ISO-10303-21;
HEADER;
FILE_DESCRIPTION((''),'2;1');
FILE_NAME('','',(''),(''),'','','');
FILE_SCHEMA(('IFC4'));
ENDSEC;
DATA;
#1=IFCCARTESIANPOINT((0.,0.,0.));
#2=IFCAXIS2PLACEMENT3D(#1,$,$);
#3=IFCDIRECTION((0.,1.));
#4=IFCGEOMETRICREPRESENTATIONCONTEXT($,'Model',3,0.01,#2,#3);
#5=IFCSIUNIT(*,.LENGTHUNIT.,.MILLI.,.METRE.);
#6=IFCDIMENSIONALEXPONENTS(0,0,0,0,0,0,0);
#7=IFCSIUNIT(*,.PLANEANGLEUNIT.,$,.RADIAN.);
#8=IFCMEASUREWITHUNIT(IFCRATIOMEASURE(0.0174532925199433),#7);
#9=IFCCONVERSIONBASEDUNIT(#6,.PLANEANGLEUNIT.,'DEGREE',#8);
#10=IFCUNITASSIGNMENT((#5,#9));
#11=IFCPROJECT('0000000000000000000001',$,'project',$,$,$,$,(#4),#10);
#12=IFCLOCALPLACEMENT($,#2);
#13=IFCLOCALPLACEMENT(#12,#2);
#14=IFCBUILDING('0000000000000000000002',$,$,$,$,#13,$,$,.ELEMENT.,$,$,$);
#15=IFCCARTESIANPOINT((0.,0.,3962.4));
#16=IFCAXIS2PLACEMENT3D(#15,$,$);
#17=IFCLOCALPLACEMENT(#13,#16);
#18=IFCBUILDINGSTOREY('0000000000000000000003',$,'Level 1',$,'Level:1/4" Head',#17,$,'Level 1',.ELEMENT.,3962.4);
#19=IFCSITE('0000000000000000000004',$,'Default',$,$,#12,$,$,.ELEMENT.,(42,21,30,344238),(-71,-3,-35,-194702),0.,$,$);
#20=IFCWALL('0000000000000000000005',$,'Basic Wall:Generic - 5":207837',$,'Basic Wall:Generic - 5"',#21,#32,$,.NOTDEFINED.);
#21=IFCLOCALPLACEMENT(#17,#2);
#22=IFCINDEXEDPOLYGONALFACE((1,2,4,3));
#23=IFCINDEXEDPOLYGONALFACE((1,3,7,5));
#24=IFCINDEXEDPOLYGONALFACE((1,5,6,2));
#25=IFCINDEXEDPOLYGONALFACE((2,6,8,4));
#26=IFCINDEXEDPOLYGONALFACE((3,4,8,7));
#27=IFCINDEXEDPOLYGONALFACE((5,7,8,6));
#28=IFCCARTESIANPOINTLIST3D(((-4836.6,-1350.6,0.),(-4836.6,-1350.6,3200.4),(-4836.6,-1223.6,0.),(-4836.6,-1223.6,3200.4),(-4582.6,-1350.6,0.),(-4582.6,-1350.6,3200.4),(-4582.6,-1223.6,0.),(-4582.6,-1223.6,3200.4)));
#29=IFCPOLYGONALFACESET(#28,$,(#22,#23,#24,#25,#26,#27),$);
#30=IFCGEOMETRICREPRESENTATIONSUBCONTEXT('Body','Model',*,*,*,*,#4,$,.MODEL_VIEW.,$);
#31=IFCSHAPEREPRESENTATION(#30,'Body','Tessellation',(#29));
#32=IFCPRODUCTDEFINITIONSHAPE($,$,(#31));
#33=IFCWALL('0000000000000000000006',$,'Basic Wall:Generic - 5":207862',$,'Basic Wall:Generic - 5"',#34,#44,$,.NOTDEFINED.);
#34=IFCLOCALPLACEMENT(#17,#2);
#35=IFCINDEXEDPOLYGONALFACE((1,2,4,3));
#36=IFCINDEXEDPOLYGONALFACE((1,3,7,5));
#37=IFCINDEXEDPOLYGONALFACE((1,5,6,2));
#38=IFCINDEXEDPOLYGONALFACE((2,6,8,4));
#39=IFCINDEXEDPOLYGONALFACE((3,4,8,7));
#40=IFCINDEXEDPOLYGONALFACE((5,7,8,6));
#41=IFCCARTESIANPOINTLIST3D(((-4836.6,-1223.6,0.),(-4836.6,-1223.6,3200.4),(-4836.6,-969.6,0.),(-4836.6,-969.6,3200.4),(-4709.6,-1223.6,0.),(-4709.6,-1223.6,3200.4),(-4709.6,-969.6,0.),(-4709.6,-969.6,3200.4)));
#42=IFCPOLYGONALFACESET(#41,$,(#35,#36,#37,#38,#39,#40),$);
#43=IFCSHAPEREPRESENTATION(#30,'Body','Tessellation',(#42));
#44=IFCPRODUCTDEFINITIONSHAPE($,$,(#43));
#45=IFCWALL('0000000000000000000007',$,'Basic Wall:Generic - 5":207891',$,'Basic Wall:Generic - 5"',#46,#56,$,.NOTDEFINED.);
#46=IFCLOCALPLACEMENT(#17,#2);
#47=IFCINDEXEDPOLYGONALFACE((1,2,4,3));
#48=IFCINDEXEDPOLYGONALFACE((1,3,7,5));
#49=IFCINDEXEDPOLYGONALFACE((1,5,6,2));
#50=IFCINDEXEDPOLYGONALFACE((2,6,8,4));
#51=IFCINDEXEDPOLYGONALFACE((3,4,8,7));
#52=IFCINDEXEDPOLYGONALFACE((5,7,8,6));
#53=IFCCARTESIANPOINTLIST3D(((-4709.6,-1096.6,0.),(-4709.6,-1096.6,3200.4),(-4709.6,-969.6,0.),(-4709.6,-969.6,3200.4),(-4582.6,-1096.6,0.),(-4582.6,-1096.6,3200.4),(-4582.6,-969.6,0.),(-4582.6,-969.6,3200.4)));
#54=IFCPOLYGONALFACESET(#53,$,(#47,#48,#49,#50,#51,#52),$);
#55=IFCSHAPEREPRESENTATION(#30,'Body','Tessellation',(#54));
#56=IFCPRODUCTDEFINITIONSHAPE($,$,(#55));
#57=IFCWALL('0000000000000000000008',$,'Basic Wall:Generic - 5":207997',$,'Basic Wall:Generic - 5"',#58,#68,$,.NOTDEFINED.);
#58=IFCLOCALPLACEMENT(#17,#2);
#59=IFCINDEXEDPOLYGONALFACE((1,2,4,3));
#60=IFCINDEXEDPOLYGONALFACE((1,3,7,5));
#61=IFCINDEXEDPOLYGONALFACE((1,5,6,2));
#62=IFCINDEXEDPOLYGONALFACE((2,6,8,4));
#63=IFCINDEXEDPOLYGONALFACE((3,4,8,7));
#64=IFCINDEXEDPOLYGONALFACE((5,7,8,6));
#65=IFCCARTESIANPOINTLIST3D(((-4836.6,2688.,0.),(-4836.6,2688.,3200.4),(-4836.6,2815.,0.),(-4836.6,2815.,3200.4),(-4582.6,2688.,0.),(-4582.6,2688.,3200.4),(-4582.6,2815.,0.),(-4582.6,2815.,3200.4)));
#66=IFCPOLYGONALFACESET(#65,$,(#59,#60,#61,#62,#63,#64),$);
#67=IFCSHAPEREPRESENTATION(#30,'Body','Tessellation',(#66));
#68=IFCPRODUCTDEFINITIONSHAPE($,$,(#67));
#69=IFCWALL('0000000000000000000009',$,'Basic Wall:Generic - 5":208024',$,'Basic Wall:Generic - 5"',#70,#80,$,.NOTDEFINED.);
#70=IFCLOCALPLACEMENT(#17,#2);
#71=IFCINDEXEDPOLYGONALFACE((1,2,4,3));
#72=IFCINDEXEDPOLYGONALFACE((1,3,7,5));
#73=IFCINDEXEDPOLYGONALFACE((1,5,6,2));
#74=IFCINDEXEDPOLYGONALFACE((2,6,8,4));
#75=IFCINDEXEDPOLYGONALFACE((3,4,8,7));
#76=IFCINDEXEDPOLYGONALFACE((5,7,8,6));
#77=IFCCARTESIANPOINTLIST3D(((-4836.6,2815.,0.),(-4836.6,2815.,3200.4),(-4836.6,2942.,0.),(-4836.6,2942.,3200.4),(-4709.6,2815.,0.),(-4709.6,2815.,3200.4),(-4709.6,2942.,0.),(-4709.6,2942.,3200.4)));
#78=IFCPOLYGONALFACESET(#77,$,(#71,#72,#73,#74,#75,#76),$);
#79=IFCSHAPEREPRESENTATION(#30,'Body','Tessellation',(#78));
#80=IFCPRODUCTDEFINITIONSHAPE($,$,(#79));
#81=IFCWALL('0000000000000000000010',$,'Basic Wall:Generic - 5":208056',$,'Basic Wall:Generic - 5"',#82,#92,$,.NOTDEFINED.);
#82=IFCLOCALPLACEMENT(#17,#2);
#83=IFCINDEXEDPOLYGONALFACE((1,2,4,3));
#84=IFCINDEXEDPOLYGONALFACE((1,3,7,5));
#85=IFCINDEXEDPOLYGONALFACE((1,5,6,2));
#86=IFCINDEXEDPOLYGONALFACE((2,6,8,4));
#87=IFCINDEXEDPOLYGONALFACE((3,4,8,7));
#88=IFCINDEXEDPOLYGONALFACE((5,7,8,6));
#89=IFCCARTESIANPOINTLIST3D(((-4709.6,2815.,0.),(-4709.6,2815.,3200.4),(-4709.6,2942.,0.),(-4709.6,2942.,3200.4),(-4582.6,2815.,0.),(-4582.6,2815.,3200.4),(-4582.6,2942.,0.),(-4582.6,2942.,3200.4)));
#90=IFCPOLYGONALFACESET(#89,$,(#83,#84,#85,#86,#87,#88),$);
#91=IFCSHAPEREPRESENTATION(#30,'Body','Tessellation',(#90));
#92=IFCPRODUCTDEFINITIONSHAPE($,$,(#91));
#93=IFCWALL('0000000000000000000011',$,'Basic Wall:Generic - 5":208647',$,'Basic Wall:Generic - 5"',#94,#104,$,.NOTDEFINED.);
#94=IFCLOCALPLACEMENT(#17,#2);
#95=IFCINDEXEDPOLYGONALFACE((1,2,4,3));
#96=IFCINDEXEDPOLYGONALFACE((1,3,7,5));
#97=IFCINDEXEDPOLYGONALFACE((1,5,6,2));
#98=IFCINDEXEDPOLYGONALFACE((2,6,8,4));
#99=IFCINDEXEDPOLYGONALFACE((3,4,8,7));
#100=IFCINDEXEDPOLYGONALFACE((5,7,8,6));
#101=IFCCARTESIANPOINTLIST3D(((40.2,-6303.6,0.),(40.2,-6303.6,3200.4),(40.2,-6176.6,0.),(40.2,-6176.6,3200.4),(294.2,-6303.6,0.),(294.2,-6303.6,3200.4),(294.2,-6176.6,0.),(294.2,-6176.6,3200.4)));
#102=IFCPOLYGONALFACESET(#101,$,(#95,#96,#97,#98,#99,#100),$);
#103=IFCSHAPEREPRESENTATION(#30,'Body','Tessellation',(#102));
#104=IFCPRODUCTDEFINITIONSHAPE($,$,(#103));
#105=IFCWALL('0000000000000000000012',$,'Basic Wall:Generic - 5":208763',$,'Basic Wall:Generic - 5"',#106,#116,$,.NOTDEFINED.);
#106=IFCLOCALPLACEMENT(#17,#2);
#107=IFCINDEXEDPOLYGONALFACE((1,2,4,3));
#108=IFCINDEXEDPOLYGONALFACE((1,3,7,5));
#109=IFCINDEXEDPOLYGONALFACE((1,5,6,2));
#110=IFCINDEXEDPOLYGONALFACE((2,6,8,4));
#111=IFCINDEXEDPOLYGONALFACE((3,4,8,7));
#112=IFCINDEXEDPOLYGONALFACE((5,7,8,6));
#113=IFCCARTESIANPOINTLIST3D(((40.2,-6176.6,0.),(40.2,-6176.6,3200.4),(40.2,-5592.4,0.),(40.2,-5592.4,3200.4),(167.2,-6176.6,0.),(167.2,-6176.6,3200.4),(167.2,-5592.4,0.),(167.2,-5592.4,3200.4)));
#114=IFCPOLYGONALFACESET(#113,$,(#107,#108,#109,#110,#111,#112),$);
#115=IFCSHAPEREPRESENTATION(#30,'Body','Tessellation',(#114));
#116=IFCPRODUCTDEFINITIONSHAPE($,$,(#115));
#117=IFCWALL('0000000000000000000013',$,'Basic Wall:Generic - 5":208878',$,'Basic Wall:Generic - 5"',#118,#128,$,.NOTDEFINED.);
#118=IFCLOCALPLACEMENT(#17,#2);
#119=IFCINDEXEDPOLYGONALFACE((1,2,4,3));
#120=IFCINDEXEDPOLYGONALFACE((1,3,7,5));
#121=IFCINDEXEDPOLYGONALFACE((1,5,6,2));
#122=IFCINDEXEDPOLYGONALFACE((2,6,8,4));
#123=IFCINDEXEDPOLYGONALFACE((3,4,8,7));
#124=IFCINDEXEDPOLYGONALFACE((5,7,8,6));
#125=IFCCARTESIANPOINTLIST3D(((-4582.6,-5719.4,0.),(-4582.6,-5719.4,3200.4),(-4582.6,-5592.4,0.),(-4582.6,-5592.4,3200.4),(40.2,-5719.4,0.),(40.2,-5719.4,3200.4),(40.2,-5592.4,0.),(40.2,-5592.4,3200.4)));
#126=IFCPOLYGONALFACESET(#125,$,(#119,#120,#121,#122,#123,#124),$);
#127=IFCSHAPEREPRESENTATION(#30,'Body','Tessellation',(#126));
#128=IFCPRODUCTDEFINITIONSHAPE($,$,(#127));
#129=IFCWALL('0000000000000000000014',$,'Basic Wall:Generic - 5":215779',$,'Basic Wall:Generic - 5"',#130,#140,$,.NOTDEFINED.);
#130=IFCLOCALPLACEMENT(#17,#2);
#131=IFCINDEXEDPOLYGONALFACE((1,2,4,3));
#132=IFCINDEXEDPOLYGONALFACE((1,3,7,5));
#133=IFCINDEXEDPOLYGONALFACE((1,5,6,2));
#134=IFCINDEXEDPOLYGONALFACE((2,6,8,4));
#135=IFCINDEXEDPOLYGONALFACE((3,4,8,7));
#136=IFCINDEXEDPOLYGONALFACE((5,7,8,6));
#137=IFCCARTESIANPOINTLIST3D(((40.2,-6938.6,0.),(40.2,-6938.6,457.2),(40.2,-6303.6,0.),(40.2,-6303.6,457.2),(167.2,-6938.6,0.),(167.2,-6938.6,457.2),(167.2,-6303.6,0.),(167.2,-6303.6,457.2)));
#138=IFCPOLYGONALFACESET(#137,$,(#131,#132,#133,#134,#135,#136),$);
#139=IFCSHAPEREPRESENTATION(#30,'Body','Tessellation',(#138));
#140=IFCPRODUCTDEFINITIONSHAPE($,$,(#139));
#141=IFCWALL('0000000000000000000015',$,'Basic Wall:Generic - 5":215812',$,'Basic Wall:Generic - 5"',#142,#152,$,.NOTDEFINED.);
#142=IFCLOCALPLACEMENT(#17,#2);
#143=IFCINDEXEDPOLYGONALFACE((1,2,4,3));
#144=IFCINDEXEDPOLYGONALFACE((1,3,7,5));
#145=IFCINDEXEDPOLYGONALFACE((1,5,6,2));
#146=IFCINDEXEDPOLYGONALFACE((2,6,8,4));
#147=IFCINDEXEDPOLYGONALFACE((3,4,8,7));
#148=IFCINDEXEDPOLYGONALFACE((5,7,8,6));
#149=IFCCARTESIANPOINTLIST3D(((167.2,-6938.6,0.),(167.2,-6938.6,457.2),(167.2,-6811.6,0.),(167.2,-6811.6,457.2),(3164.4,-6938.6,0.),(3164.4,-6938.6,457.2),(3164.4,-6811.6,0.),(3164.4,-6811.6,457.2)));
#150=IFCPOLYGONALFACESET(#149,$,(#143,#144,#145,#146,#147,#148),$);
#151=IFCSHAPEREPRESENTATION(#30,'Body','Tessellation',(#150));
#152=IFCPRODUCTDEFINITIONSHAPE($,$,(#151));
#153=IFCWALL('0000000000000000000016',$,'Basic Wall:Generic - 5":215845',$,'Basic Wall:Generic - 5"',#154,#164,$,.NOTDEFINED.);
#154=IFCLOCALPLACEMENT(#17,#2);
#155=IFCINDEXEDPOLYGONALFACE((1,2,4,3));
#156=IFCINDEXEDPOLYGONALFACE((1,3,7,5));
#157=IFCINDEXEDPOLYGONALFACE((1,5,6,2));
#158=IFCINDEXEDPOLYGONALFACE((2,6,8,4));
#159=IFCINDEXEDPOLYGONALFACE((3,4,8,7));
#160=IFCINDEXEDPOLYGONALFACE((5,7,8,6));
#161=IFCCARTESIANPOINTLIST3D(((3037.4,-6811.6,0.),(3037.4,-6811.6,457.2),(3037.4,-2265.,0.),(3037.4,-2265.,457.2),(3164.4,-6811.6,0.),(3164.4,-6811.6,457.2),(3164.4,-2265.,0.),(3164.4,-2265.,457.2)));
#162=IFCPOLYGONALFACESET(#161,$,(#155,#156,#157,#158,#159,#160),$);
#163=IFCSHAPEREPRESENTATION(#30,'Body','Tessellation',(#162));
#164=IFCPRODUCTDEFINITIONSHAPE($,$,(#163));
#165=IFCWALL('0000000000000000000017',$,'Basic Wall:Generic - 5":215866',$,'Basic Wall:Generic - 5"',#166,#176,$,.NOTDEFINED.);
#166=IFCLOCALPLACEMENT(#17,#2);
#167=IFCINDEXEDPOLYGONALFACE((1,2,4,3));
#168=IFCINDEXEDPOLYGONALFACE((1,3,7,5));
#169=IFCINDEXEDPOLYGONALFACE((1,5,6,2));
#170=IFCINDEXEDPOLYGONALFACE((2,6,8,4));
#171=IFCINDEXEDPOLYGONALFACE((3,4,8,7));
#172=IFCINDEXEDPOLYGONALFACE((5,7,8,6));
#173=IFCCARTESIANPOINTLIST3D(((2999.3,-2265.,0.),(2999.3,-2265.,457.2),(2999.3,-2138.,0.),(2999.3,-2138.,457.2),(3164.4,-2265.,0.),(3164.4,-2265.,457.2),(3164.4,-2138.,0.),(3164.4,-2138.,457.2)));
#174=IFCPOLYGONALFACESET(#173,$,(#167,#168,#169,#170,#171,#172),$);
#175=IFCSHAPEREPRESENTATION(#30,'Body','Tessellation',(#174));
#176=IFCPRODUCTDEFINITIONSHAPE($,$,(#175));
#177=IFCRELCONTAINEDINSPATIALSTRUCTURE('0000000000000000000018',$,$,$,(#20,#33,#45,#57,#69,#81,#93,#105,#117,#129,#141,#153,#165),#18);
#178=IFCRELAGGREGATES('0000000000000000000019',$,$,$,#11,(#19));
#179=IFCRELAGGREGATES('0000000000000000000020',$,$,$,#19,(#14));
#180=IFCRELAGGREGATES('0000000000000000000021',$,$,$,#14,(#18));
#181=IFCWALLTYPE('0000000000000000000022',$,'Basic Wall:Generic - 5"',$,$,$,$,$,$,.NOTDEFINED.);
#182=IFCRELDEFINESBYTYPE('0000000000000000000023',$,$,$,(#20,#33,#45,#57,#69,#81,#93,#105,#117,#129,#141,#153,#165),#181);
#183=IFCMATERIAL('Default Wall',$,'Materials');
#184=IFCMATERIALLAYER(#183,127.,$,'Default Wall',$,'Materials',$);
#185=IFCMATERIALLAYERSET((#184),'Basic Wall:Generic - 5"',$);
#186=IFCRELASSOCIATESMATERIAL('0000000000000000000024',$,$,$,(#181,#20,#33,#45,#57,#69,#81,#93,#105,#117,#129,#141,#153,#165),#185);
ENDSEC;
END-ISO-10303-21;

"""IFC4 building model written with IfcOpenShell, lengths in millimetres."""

from ifc_helpers import new_model, entity, si_unit, converted_unit, direction, frame, origin, place, context, subcontext, project, spatial, indexed_curve, outline, extrude, material, layer, layer_set, type_object, element, save


model = new_model("IFC4")

# Units and contexts
model_context = context("Model", 3, precision=0.01, world=origin(), true_north=direction((0.0, 1.0)))
body_context = subcontext(model_context, "Body", "Model", "MODEL_VIEW")
ifc_project = project(units=[si_unit("LENGTHUNIT", "METRE", prefix="MILLI"), converted_unit("PLANEANGLEUNIT", "DEGREE", entity("IfcRatioMeasure", 0.0174532925199433), si_unit("PLANEANGLEUNIT", "RADIAN"), dimensions=[0, 0, 0, 0, 0, 0, 0])], contexts=[model_context])

# Site, building, storey
site_placement = place(None, origin())
site = spatial("IfcSite", under=ifc_project, at=site_placement, Name="Default", CompositionType="ELEMENT", RefLatitude=(42, 21, 30, 344238), RefLongitude=(-71, -3, -35, -194702), RefElevation=0.0)
building_placement = place(site_placement, origin())
building = spatial("IfcBuilding", under=site, at=building_placement, CompositionType="ELEMENT")
storey_placement = place(building_placement, frame((0.0, 0.0, 3962.4)))
storey = spatial("IfcBuildingStorey", under=building, at=storey_placement, Name="Level 1", ObjectType="Level:1/4\" Head", LongName="Level 1", CompositionType="ELEMENT", Elevation=3962.4)

# Walls
ifc_material_1 = material(Name="Default Wall", Category="Materials")
ifc_layer_1 = layer(ifc_material_1, 127.0, Name="Default Wall", Category="Materials")
ifc_layer_set_1 = layer_set([ifc_layer_1], Name="Basic Wall:Generic - 5\"")
wall_type = type_object("IfcWallType", Name="Basic Wall:Generic - 5\"", PredefinedType="NOTDEFINED", material=ifc_layer_set_1)
wall_1_placement = place(storey_placement, frame((-4582.6, -1287.1, 0.0), z_axis=(0.0, 0.0, 1.0), x_axis=(-1.0, 0.0, 0.0)))
element("IfcWall", 1, at=wall_1_placement, inside=storey, type_object=wall_type, material=ifc_layer_set_1, Name="Basic Wall:Generic - 5\":207837", ObjectType="Basic Wall:Generic - 5\"", PredefinedType="NOTDEFINED", context=body_context, shape_type="SweptSolid", body=[
    extrude(outline(indexed_curve([(254.0, 63.5), (0.0, 63.5), (0.0, -63.5), (254.0, -63.5), (254.0, 63.5)], self_intersect=False)), origin(), (0.0, 0.0, 1.0), 3200.4),
])
wall_2_placement = place(storey_placement, frame((-4773.1, -1223.6, 0.0), z_axis=(0.0, 0.0, 1.0), x_axis=(0.0, 1.0, 0.0)))
element("IfcWall", 2, at=wall_2_placement, inside=storey, type_object=wall_type, material=ifc_layer_set_1, Name="Basic Wall:Generic - 5\":207862", ObjectType="Basic Wall:Generic - 5\"", PredefinedType="NOTDEFINED", context=body_context, shape_type="SweptSolid", body=[
    extrude(outline(indexed_curve([(254.0, 63.5), (0.0, 63.5), (0.0, -63.5), (254.0, -63.5), (254.0, 63.5)], self_intersect=False)), origin(), (0.0, 0.0, 1.0), 3200.4),
])
wall_3_placement = place(storey_placement, frame((-4709.6, -1033.1, 0.0)))
element("IfcWall", 3, at=wall_3_placement, inside=storey, type_object=wall_type, material=ifc_layer_set_1, Name="Basic Wall:Generic - 5\":207891", ObjectType="Basic Wall:Generic - 5\"", PredefinedType="NOTDEFINED", context=body_context, shape_type="SweptSolid", body=[
    extrude(outline(indexed_curve([(127.0, 63.5), (0.0, 63.5), (0.0, -63.5), (127.0, -63.5), (127.0, 63.5)], self_intersect=False)), origin(), (0.0, 0.0, 1.0), 3200.4),
])
wall_4_placement = place(storey_placement, frame((-4582.6, 2751.5, 0.0), z_axis=(0.0, 0.0, 1.0), x_axis=(-1.0, 0.0, 0.0)))
element("IfcWall", 4, at=wall_4_placement, inside=storey, type_object=wall_type, material=ifc_layer_set_1, Name="Basic Wall:Generic - 5\":207997", ObjectType="Basic Wall:Generic - 5\"", PredefinedType="NOTDEFINED", context=body_context, shape_type="SweptSolid", body=[
    extrude(outline(indexed_curve([(254.0, 63.5), (0.0, 63.5), (0.0, -63.5), (254.0, -63.5), (254.0, 63.5)], self_intersect=False)), origin(), (0.0, 0.0, 1.0), 3200.4),
])
wall_5_placement = place(storey_placement, frame((-4773.1, 2815.0, 0.0), z_axis=(0.0, 0.0, 1.0), x_axis=(0.0, 1.0, 0.0)))
element("IfcWall", 5, at=wall_5_placement, inside=storey, type_object=wall_type, material=ifc_layer_set_1, Name="Basic Wall:Generic - 5\":208024", ObjectType="Basic Wall:Generic - 5\"", PredefinedType="NOTDEFINED", context=body_context, shape_type="SweptSolid", body=[
    extrude(outline(indexed_curve([(127.0, 63.5), (0.0, 63.5), (0.0, -63.5), (127.0, -63.5), (127.0, 63.5)], self_intersect=False)), origin(), (0.0, 0.0, 1.0), 3200.4),
])
wall_6_placement = place(storey_placement, frame((-4709.6, 2878.5, 0.0)))
element("IfcWall", 6, at=wall_6_placement, inside=storey, type_object=wall_type, material=ifc_layer_set_1, Name="Basic Wall:Generic - 5\":208056", ObjectType="Basic Wall:Generic - 5\"", PredefinedType="NOTDEFINED", context=body_context, shape_type="SweptSolid", body=[
    extrude(outline(indexed_curve([(127.0, 63.5), (0.0, 63.5), (0.0, -63.5), (127.0, -63.5), (127.0, 63.5)], self_intersect=False)), origin(), (0.0, 0.0, 1.0), 3200.4),
])
wall_7_placement = place(storey_placement, frame((294.2, -6240.1, 0.0), z_axis=(0.0, 0.0, 1.0), x_axis=(-1.0, 0.0, 0.0)))
element("IfcWall", 7, at=wall_7_placement, inside=storey, type_object=wall_type, material=ifc_layer_set_1, Name="Basic Wall:Generic - 5\":208647", ObjectType="Basic Wall:Generic - 5\"", PredefinedType="NOTDEFINED", context=body_context, shape_type="SweptSolid", body=[
    extrude(outline(indexed_curve([(254.0, 63.5), (0.0, 63.5), (0.0, -63.5), (254.0, -63.5), (254.0, 63.5)], self_intersect=False)), origin(), (0.0, 0.0, 1.0), 3200.4),
])
wall_8_placement = place(storey_placement, frame((103.7, -5592.4, 0.0), z_axis=(0.0, 0.0, 1.0), x_axis=(0.0, -1.0, 0.0)))
element("IfcWall", 8, at=wall_8_placement, inside=storey, type_object=wall_type, material=ifc_layer_set_1, Name="Basic Wall:Generic - 5\":208763", ObjectType="Basic Wall:Generic - 5\"", PredefinedType="NOTDEFINED", context=body_context, shape_type="SweptSolid", body=[
    extrude(outline(indexed_curve([(584.2, 63.5), (0.0, 63.5), (0.0, -63.5), (584.2, -63.5), (584.2, 63.5)], self_intersect=False)), origin(), (0.0, 0.0, 1.0), 3200.4),
])
wall_9_placement = place(storey_placement, frame((40.2, -5655.9, 0.0), z_axis=(0.0, 0.0, 1.0), x_axis=(-1.0, 0.0, 0.0)))
element("IfcWall", 9, at=wall_9_placement, inside=storey, type_object=wall_type, material=ifc_layer_set_1, Name="Basic Wall:Generic - 5\":208878", ObjectType="Basic Wall:Generic - 5\"", PredefinedType="NOTDEFINED", context=body_context, shape_type="SweptSolid", body=[
    extrude(outline(indexed_curve([(4622.8, 63.5), (0.0, 63.5), (0.0, -63.5), (4622.8, -63.5), (4622.8, 63.5)], self_intersect=False)), origin(), (0.0, 0.0, 1.0), 3200.4),
])
wall_10_placement = place(storey_placement, frame((103.7, -6303.6, 0.0), z_axis=(0.0, 0.0, 1.0), x_axis=(0.0, -1.0, 0.0)))
element("IfcWall", 10, at=wall_10_placement, inside=storey, type_object=wall_type, material=ifc_layer_set_1, Name="Basic Wall:Generic - 5\":215779", ObjectType="Basic Wall:Generic - 5\"", PredefinedType="NOTDEFINED", context=body_context, shape_type="SweptSolid", body=[
    extrude(outline(indexed_curve([(635.0, 63.5), (0.0, 63.5), (0.0, -63.5), (635.0, -63.5), (635.0, 63.5)], self_intersect=False)), origin(), (0.0, 0.0, 1.0), 457.2),
])
wall_11_placement = place(storey_placement, frame((167.2, -6875.1, 0.0)))
element("IfcWall", 11, at=wall_11_placement, inside=storey, type_object=wall_type, material=ifc_layer_set_1, Name="Basic Wall:Generic - 5\":215812", ObjectType="Basic Wall:Generic - 5\"", PredefinedType="NOTDEFINED", context=body_context, shape_type="SweptSolid", body=[
    extrude(outline(indexed_curve([(2997.2, 63.5), (0.0, 63.5), (0.0, -63.5), (2997.2, -63.5), (2997.2, 63.5)], self_intersect=False)), origin(), (0.0, 0.0, 1.0), 457.2),
])
wall_12_placement = place(storey_placement, frame((3100.9, -6811.6, 0.0), z_axis=(0.0, 0.0, 1.0), x_axis=(0.0, 1.0, 0.0)))
element("IfcWall", 12, at=wall_12_placement, inside=storey, type_object=wall_type, material=ifc_layer_set_1, Name="Basic Wall:Generic - 5\":215845", ObjectType="Basic Wall:Generic - 5\"", PredefinedType="NOTDEFINED", context=body_context, shape_type="SweptSolid", body=[
    extrude(outline(indexed_curve([(4546.6, 63.5), (0.0, 63.5), (0.0, -63.5), (4546.6, -63.5), (4546.6, 63.5)], self_intersect=False)), origin(), (0.0, 0.0, 1.0), 457.2),
])
wall_13_placement = place(storey_placement, frame((3164.4, -2201.5, 0.0), z_axis=(0.0, 0.0, 1.0), x_axis=(-1.0, 0.0, 0.0)))
element("IfcWall", 13, at=wall_13_placement, inside=storey, type_object=wall_type, material=ifc_layer_set_1, Name="Basic Wall:Generic - 5\":215866", ObjectType="Basic Wall:Generic - 5\"", PredefinedType="NOTDEFINED", context=body_context, shape_type="SweptSolid", body=[
    extrude(outline(indexed_curve([(165.1, 63.5), (0.0, 63.5), (0.0, -63.5), (165.1, -63.5), (165.1, 63.5)], self_intersect=False)), origin(), (0.0, 0.0, 1.0), 457.2),
])

save(model, "model.ifc")
